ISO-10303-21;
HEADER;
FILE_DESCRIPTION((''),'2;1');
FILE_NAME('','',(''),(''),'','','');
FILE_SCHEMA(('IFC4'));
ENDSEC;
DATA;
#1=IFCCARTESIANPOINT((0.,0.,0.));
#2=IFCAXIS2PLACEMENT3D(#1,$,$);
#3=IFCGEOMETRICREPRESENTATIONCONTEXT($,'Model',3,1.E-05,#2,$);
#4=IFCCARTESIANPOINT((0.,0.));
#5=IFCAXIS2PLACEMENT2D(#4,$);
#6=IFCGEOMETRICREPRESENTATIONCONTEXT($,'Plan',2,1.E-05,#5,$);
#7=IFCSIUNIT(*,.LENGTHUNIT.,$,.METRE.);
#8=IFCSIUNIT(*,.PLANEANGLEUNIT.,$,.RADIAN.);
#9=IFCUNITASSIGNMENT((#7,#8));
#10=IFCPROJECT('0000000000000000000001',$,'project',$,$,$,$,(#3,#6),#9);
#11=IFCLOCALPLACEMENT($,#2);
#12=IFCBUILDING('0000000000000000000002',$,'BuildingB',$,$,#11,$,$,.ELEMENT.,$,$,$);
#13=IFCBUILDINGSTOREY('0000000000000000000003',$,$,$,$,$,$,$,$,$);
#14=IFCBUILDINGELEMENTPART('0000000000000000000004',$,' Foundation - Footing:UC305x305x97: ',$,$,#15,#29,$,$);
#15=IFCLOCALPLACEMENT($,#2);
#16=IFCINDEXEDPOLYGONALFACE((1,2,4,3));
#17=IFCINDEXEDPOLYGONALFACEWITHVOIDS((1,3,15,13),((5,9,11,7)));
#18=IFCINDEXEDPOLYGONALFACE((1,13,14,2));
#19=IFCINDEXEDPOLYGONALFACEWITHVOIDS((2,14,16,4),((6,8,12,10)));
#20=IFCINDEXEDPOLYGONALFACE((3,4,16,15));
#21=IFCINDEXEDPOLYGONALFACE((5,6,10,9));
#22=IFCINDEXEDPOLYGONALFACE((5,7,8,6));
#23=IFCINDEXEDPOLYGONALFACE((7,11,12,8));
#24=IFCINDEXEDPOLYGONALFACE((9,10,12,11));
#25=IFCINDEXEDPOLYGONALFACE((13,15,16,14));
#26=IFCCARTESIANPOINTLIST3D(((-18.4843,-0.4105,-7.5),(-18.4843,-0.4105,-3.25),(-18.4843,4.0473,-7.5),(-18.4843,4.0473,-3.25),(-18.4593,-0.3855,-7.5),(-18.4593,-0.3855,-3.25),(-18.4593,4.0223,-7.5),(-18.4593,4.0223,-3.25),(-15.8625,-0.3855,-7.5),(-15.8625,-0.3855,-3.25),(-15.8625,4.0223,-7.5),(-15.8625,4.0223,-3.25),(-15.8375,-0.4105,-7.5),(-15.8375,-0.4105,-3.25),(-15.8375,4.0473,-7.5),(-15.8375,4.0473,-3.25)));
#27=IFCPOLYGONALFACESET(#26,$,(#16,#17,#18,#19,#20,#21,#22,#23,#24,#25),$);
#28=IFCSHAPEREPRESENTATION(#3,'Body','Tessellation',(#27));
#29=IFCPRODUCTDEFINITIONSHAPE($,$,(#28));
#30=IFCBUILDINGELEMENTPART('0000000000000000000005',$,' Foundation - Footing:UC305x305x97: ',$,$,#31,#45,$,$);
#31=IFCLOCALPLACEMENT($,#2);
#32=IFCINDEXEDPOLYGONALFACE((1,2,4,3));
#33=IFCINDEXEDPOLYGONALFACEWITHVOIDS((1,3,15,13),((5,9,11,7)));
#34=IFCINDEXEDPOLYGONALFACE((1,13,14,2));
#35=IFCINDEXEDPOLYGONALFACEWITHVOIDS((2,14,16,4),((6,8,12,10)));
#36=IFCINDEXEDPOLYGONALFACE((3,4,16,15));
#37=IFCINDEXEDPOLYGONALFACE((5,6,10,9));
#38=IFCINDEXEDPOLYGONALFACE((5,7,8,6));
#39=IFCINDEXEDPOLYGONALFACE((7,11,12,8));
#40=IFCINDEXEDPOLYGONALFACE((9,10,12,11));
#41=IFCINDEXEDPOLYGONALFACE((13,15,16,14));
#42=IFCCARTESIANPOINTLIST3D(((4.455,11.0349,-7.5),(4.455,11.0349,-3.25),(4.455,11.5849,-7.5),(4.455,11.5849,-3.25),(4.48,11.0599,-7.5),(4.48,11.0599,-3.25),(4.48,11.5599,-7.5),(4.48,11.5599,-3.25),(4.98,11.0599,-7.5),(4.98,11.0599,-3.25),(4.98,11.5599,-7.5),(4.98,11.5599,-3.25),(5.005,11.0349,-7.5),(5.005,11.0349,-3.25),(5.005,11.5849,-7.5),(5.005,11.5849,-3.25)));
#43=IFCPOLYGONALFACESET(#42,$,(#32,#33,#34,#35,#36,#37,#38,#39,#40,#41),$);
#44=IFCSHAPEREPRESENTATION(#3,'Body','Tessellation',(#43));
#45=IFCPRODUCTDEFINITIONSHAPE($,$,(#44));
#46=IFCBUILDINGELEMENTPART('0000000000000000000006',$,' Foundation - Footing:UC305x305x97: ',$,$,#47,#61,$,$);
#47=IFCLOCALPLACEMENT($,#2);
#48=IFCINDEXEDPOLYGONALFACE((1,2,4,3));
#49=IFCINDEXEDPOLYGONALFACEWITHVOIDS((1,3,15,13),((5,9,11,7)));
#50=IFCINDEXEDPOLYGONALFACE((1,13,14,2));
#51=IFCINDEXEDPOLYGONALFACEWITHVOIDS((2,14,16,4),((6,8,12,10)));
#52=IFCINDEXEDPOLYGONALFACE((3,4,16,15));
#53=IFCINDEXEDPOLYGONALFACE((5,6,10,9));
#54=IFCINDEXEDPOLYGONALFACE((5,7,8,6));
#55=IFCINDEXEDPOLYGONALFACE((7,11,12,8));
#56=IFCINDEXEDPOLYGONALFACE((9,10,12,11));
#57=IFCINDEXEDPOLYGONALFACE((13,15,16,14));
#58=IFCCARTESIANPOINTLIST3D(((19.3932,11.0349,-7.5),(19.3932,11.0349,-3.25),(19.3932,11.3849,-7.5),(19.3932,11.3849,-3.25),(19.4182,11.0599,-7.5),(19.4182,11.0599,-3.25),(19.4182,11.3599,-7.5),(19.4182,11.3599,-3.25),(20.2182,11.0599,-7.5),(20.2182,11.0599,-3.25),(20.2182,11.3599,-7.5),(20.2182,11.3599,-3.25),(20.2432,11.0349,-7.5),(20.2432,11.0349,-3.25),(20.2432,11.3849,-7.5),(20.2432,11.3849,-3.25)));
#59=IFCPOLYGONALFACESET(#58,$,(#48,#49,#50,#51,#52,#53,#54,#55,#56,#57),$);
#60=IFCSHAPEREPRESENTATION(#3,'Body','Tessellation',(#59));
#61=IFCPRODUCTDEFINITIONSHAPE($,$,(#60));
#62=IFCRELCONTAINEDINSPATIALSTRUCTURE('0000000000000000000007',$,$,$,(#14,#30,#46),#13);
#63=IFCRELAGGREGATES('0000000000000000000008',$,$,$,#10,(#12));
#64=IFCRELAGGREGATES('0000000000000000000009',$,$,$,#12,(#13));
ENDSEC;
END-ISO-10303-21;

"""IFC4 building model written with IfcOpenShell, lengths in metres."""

from ifc_helpers import new_model, si_unit, origin, origin_2d, place, context, project, spatial, polyline, outline, extrude, element, save


model = new_model("IFC4")

# Units and contexts
model_context = context("Model", 3, precision=1e-05, world=origin())
plan_context = context("Plan", 2, precision=1e-05, world=origin_2d())
ifc_project = project(units=[si_unit("LENGTHUNIT", "METRE"), si_unit("PLANEANGLEUNIT", "RADIAN")], contexts=[model_context, plan_context])

# Building, storey
building_placement = place(None, origin())
building = spatial("IfcBuilding", under=ifc_project, at=building_placement, Name="BuildingB", CompositionType="ELEMENT")
storey = spatial("IfcBuildingStorey", under=building)

# Building element parts, openings
building_element_part_1 = element("IfcBuildingElementPart", 1, inside=storey, Name=" Foundation - Footing:UC305x305x97: ", context=model_context, shape_type="SweptSolid", body=[
    extrude(outline(polyline([(-18.4843, -0.4105, -7.5), (-15.8375, -0.4105, -7.5), (-15.8375, 4.0473, -7.5), (-18.4843, 4.0473, -7.5), (-18.4843, -0.4105, -7.5)])), None, (0.0, 0.0, 1.0), 4.25),
])
element("IfcOpeningElement", 2, inside=storey, cuts=building_element_part_1, context=model_context, shape_type="SweptSolid", body=[
    extrude(outline(polyline([(-18.4593, -0.3855, -7.5), (-15.8625, -0.3855, -7.5), (-15.8625, 4.0223, -7.5), (-18.4593, 4.0223, -7.5), (-18.4593, -0.3855, -7.5)])), None, (0.0, 0.0, 1.0), 4.25),
])
building_element_part_2 = element("IfcBuildingElementPart", 3, inside=storey, Name=" Foundation - Footing:UC305x305x97: ", context=model_context, shape_type="SweptSolid", body=[
    extrude(outline(polyline([(5.005, 11.0349, -7.5), (4.455, 11.0349, -7.5), (4.455, 11.5849, -7.5), (5.005, 11.5849, -7.5), (5.005, 11.0349, -7.5)])), None, (0.0, 0.0, 1.0), 4.25),
])
element("IfcOpeningElement", 4, inside=storey, cuts=building_element_part_2, context=model_context, shape_type="SweptSolid", body=[
    extrude(outline(polyline([(4.98, 11.0599, -7.5), (4.48, 11.0599, -7.5), (4.48, 11.5599, -7.5), (4.98, 11.5599, -7.5), (4.98, 11.0599, -7.5)])), None, (0.0, 0.0, 1.0), 4.25),
])
building_element_part_3 = element("IfcBuildingElementPart", 5, inside=storey, Name=" Foundation - Footing:UC305x305x97: ", context=model_context, shape_type="SweptSolid", body=[
    extrude(outline(polyline([(19.3932, 11.0349, -7.5), (20.2432, 11.0349, -7.5), (20.2432, 11.3849, -7.5), (19.3932, 11.3849, -7.5), (19.3932, 11.0349, -7.5)])), None, (0.0, 0.0, 1.0), 4.25),
])
element("IfcOpeningElement", 6, inside=storey, cuts=building_element_part_3, context=model_context, shape_type="SweptSolid", body=[
    extrude(outline(polyline([(19.4182, 11.0599, -7.5), (20.2182, 11.0599, -7.5), (20.2182, 11.3599, -7.5), (19.4182, 11.3599, -7.5), (19.4182, 11.0599, -7.5)])), None, (0.0, 0.0, 1.0), 4.25),
])

save(model, "model.ifc")
